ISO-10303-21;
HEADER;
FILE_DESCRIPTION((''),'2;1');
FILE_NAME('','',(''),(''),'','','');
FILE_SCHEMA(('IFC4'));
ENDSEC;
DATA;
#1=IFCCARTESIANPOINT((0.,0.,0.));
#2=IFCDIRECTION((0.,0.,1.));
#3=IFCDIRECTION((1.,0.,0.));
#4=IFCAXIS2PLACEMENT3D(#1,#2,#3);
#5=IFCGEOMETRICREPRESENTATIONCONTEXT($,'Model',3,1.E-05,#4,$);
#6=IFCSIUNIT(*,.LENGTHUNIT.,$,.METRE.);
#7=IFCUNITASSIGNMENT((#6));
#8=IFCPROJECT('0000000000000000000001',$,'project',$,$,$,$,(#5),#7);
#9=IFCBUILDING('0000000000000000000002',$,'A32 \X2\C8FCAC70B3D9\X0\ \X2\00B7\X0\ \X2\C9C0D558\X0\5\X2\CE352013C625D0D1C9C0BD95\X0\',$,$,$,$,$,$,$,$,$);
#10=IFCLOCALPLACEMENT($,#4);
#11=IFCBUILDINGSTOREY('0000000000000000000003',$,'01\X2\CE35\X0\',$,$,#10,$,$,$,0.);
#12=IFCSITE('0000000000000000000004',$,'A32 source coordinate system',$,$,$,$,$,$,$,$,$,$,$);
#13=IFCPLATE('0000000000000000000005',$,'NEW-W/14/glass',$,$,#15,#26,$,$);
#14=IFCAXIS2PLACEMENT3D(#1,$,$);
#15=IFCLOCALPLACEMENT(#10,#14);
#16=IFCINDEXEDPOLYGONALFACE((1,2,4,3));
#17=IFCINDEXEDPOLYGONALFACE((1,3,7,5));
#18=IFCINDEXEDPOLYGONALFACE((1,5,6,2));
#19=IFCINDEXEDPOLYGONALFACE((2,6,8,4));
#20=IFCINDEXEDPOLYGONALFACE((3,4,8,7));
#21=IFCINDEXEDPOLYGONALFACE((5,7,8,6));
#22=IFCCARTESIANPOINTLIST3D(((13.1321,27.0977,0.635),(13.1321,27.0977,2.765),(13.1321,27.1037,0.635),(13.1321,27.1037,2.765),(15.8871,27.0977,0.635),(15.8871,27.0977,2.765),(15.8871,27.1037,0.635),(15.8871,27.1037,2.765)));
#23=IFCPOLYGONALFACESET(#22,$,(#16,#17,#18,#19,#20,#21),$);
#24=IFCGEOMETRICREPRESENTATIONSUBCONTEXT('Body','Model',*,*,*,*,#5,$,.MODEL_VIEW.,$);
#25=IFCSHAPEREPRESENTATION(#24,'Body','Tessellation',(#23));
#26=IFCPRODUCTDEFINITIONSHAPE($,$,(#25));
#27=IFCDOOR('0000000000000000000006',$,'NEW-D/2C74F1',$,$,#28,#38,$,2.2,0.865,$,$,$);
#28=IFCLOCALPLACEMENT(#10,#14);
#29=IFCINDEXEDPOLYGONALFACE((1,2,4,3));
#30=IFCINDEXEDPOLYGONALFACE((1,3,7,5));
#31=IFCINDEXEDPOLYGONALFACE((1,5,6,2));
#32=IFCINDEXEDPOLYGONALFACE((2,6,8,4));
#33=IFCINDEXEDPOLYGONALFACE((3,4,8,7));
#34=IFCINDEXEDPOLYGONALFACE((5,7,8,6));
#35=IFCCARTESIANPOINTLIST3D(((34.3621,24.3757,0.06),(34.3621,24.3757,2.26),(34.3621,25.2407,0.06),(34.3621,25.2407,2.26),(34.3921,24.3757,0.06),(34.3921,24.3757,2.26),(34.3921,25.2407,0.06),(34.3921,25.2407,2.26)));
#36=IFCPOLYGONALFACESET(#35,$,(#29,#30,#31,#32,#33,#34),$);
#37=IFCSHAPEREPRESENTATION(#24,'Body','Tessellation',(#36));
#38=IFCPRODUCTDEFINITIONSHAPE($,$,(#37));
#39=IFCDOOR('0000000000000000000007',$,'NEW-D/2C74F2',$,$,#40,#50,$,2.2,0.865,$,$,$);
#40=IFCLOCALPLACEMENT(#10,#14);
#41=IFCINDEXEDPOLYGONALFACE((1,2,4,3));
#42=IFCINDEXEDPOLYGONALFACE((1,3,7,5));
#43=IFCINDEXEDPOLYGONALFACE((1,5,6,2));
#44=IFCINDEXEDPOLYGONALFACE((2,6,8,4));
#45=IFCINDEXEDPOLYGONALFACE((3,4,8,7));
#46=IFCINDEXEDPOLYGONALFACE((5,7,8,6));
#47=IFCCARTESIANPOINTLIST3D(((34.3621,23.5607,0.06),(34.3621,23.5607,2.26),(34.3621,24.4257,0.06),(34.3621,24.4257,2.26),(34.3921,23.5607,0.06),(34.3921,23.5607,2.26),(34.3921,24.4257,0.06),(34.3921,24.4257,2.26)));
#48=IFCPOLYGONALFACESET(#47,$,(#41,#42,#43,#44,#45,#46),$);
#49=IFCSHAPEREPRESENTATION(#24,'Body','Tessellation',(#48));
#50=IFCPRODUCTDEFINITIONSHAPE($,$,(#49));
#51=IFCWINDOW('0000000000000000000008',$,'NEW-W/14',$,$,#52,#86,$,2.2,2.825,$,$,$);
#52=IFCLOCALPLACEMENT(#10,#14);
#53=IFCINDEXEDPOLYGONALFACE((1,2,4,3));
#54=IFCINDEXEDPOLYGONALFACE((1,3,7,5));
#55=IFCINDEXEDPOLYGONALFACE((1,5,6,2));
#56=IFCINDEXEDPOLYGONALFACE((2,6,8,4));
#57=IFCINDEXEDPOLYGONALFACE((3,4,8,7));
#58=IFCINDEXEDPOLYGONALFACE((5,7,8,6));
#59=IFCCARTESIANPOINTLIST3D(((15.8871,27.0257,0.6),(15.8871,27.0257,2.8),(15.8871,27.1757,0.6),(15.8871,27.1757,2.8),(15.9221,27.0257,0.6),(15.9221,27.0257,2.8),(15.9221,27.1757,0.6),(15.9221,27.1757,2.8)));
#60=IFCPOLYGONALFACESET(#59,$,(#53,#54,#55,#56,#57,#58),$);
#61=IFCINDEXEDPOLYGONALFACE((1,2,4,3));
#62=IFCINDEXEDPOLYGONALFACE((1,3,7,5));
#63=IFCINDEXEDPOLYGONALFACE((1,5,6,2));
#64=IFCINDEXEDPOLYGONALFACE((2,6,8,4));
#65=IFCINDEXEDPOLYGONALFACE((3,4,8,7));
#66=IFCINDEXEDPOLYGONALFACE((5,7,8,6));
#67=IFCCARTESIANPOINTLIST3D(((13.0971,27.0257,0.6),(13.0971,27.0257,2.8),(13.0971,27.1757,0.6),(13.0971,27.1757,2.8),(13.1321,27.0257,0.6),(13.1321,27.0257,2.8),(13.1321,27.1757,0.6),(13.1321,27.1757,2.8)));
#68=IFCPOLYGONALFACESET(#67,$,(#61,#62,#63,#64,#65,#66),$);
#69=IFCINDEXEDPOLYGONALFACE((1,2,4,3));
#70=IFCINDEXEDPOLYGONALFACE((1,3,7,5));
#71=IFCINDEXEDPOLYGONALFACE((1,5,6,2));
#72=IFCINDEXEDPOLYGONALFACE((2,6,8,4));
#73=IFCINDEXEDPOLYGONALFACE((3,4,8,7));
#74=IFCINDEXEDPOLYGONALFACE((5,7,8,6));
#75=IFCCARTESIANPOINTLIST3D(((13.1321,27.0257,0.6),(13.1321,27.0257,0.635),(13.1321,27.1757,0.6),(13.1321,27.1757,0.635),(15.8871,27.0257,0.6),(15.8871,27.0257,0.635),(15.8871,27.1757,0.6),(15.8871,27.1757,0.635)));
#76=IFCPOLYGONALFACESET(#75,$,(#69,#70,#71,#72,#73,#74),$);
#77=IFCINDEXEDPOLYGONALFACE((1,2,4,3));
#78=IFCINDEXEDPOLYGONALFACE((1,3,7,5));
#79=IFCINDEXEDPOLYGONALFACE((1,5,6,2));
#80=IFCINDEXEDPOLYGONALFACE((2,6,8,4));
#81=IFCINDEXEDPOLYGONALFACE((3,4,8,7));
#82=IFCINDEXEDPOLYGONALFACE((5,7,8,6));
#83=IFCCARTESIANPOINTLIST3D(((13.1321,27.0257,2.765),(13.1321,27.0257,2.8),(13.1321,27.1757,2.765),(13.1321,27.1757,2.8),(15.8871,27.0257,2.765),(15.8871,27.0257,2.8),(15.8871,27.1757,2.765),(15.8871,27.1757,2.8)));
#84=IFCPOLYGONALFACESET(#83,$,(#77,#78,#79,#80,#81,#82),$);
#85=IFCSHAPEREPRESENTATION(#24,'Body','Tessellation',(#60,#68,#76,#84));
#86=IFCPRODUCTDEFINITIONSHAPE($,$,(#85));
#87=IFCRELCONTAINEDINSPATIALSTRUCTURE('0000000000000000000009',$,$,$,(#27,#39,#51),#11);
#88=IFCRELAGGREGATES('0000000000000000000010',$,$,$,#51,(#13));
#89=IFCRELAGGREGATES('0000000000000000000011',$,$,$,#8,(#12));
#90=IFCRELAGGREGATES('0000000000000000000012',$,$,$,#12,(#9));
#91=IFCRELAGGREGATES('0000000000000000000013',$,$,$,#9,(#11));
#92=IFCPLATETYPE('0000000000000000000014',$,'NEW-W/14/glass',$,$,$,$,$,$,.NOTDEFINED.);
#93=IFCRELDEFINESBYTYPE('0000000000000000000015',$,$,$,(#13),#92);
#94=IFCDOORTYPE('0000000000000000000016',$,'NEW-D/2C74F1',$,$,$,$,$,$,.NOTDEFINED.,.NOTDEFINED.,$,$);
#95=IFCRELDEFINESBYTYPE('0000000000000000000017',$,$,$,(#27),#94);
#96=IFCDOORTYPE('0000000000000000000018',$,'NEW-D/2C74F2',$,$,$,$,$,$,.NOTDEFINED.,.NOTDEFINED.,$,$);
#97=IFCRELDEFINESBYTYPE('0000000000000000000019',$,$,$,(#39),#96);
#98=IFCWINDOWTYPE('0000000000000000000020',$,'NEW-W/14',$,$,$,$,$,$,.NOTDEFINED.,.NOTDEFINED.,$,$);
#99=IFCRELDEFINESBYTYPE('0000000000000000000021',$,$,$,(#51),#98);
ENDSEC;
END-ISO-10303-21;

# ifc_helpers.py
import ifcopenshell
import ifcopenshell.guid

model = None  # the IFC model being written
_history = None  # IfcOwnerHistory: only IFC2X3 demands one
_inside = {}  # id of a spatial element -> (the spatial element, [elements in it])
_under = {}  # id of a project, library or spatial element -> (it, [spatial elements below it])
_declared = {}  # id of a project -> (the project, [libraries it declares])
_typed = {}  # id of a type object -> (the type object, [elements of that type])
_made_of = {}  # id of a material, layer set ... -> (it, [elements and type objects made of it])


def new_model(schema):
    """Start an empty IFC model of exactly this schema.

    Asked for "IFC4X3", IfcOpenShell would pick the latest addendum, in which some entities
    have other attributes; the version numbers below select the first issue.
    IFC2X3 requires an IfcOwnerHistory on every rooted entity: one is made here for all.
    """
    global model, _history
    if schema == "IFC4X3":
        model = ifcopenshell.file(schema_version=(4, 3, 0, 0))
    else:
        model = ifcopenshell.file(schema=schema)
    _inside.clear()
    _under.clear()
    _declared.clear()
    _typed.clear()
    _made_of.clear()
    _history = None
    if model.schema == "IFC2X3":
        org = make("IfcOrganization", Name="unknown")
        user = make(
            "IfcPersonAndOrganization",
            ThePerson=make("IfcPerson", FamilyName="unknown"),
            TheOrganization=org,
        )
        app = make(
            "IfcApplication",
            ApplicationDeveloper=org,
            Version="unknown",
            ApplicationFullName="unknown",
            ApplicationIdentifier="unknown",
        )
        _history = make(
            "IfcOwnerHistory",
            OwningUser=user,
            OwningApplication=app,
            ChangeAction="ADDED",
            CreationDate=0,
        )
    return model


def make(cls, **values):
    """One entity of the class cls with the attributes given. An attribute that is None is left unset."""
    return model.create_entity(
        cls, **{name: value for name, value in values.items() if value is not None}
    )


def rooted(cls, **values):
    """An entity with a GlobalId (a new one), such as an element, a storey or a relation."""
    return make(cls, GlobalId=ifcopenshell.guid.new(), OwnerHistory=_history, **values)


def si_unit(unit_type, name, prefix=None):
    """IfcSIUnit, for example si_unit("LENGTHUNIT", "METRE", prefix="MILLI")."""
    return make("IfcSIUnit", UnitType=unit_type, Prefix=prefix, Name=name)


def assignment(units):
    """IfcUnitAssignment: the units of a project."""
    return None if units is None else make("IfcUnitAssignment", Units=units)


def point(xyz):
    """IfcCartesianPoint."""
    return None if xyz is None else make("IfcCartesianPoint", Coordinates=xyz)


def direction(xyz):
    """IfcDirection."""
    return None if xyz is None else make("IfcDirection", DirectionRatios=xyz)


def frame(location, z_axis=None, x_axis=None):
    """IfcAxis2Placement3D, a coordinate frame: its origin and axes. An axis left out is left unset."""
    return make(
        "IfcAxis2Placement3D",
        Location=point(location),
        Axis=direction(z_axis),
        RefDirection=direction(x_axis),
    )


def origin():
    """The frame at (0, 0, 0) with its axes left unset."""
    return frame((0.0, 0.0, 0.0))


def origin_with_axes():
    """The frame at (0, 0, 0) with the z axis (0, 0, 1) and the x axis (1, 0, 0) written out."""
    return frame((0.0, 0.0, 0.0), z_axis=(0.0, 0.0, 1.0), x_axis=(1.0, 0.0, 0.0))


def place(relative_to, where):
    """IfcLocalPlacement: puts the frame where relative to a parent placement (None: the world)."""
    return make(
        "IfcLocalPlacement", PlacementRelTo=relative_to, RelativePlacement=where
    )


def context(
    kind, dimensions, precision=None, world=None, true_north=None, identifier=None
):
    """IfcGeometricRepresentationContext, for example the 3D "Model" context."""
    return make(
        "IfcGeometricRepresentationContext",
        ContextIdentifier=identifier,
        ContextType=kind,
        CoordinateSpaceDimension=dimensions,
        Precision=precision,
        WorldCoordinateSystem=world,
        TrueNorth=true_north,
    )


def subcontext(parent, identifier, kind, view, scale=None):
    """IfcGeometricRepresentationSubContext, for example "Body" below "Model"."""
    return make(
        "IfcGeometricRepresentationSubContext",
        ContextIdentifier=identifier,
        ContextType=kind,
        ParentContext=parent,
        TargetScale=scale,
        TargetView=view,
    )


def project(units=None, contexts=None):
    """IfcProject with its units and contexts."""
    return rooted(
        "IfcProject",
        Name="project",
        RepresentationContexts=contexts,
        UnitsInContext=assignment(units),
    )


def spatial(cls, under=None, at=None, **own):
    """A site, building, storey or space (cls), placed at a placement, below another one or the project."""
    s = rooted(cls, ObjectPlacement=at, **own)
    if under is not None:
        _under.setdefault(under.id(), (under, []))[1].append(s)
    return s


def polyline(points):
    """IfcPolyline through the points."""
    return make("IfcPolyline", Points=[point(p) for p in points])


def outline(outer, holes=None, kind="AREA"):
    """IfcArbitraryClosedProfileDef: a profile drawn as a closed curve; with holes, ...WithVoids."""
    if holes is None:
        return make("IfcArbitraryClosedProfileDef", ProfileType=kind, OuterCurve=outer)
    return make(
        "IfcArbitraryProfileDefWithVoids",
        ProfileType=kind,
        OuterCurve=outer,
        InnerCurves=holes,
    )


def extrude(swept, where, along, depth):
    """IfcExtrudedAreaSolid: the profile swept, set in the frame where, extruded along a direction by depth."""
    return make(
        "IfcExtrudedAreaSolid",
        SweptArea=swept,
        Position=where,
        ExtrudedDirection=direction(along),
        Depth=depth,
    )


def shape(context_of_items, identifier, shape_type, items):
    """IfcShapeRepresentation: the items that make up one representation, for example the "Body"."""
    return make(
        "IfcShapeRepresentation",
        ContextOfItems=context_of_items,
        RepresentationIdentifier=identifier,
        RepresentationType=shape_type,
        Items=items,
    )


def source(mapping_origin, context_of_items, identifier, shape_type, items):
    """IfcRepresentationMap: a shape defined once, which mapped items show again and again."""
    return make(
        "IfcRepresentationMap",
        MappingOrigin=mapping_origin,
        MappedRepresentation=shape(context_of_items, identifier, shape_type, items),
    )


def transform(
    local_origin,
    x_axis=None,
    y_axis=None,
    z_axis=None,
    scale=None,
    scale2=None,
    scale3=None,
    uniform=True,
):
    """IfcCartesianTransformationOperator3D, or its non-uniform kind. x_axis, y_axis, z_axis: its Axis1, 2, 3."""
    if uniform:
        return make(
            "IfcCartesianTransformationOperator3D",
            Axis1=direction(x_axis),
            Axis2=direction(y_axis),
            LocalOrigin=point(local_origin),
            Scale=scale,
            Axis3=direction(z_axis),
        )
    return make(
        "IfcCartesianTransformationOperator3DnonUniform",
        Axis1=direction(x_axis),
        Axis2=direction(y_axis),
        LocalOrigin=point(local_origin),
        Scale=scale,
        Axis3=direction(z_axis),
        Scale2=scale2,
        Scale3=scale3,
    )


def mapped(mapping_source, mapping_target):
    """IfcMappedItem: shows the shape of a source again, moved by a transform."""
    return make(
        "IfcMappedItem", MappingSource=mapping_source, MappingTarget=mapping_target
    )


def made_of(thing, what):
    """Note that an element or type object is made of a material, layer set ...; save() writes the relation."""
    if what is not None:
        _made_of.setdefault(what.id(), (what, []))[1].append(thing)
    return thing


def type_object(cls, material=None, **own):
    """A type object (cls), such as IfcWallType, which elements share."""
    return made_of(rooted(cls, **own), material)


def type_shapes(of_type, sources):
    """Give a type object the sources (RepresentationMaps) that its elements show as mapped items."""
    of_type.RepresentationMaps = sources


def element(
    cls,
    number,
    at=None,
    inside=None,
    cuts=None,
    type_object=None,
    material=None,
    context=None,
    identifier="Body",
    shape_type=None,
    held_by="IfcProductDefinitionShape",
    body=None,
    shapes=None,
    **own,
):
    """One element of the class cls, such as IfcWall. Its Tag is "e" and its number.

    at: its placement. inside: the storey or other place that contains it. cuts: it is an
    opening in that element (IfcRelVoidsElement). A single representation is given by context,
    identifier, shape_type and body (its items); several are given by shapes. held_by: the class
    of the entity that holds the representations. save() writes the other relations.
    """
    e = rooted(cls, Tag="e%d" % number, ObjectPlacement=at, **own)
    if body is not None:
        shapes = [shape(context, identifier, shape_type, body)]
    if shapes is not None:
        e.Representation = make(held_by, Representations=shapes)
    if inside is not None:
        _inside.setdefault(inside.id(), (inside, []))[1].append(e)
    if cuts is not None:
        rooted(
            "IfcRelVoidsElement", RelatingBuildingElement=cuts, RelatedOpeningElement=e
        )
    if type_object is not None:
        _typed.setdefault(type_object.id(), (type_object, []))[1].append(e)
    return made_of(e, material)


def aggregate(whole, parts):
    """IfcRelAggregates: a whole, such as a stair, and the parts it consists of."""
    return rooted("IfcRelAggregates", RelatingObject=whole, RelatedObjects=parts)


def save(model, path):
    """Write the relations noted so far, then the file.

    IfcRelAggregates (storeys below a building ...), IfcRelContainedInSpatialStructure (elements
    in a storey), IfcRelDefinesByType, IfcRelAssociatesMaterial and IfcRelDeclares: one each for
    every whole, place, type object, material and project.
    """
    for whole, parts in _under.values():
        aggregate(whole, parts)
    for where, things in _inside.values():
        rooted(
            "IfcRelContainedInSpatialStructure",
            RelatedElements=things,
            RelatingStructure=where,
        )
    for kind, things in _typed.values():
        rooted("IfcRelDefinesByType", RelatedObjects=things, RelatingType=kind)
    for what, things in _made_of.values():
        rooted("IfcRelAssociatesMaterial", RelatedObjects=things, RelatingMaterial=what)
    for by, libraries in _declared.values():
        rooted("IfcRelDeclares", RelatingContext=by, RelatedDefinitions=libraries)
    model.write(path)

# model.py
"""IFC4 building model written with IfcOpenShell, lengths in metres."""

from ifc_helpers import new_model, si_unit, frame, origin, origin_with_axes, place, context, subcontext, project, spatial, polyline, outline, extrude, source, transform, mapped, type_object, type_shapes, element, aggregate, save


model = new_model("IFC4")

# Units and contexts
model_context = context("Model", 3, precision=1e-05, world=origin_with_axes())
body_context = subcontext(model_context, "Body", "Model", "MODEL_VIEW")
ifc_project = project(units=[si_unit("LENGTHUNIT", "METRE")], contexts=[model_context])

# Plate
storey_placement = place(None, origin_with_axes())
plate_type_1 = type_object("IfcPlateType", Name="NEW-W/14/glass", PredefinedType="NOTDEFINED")
shared_shape_1 = source(origin(), body_context, "Body", "SweptSolid", [
    extrude(outline(polyline([(15.8871, 27.0977), (13.1321, 27.0977), (13.1321, 27.1037), (15.8871, 27.1037), (15.8871, 27.0977)])), frame((0.0, 0.0, 0.635)), (0.0, 0.0, 1.0), 2.13),
])
type_shapes(plate_type_1, [shared_shape_1])
window_1_placement = place(storey_placement, origin_with_axes())
plate_1_placement = place(window_1_placement, origin_with_axes())
plate_1 = element("IfcPlate", 1, at=plate_1_placement, type_object=plate_type_1, Name="NEW-W/14/glass", context=body_context, shape_type="MappedRepresentation", body=[
    mapped(shared_shape_1, transform((0.0, 0.0, 0.0), scale=1.0)),
])

# Site, building, storey
site = spatial("IfcSite", under=ifc_project, Name="A32 source coordinate system")
building = spatial("IfcBuilding", under=site, Name="A32 주거동 · 지하5층–옥탑지붕")
storey = spatial("IfcBuildingStorey", under=building, at=storey_placement, Name="01층", Elevation=0.0)

# Doors
door_type_1 = type_object("IfcDoorType", Name="NEW-D/2C74F1", OperationType="NOTDEFINED", PredefinedType="NOTDEFINED")
shared_shape_2 = source(origin(), body_context, "Body", "SweptSolid", [
    extrude(outline(polyline([(34.3621, 24.3757), (34.3621, 25.2407), (34.3921, 25.2407), (34.3921, 24.3757), (34.3621, 24.3757)])), frame((0.0, 0.0, 0.06)), (0.0, 0.0, 1.0), 2.2),
])
type_shapes(door_type_1, [shared_shape_2])
door_1_placement = place(storey_placement, origin_with_axes())
element("IfcDoor", 2, at=door_1_placement, inside=storey, type_object=door_type_1, Name="NEW-D/2C74F1", OverallHeight=2.2, OverallWidth=0.865, context=body_context, shape_type="MappedRepresentation", body=[
    mapped(shared_shape_2, transform((0.0, 0.0, 0.0), scale=1.0)),
])
door_type_2 = type_object("IfcDoorType", Name="NEW-D/2C74F2", OperationType="NOTDEFINED", PredefinedType="NOTDEFINED")
shared_shape_3 = source(origin(), body_context, "Body", "SweptSolid", [
    extrude(outline(polyline([(34.3921, 23.5607), (34.3621, 23.5607), (34.3621, 24.4257), (34.3921, 24.4257), (34.3921, 23.5607)])), frame((0.0, 0.0, 0.06)), (0.0, 0.0, 1.0), 2.2),
])
type_shapes(door_type_2, [shared_shape_3])
door_2_placement = place(storey_placement, origin_with_axes())
element("IfcDoor", 3, at=door_2_placement, inside=storey, type_object=door_type_2, Name="NEW-D/2C74F2", OverallHeight=2.2, OverallWidth=0.865, context=body_context, shape_type="MappedRepresentation", body=[
    mapped(shared_shape_3, transform((0.0, 0.0, 0.0), scale=1.0)),
])

# Window
window_type_1 = type_object("IfcWindowType", Name="NEW-W/14", PartitioningType="NOTDEFINED", PredefinedType="NOTDEFINED")
shared_shape_4 = source(origin(), body_context, "Body", "SweptSolid", [
    extrude(outline(polyline([(15.8871, 27.0257), (15.8871, 27.1757), (15.9221, 27.1757), (15.9221, 27.0257), (15.8871, 27.0257)])), frame((0.0, 0.0, 0.6)), (0.0, 0.0, 1.0), 2.2),
    extrude(outline(polyline([(13.0971, 27.0257), (13.0971, 27.1757), (13.1321, 27.1757), (13.1321, 27.0257), (13.0971, 27.0257)])), frame((0.0, 0.0, 0.6)), (0.0, 0.0, 1.0), 2.2),
    extrude(outline(polyline([(15.8871, 27.0257), (15.8871, 27.1757), (13.1321, 27.1757), (13.1321, 27.0257), (15.8871, 27.0257)])), frame((0.0, 0.0, 0.6)), (0.0, 0.0, 1.0), 0.035),
    extrude(outline(polyline([(15.8871, 27.0257), (15.8871, 27.1757), (13.1321, 27.1757), (13.1321, 27.0257), (15.8871, 27.0257)])), frame((0.0, 0.0, 2.765)), (0.0, 0.0, 1.0), 0.035),
])
type_shapes(window_type_1, [shared_shape_4])
window_1 = element("IfcWindow", 4, at=window_1_placement, inside=storey, type_object=window_type_1, Name="NEW-W/14", OverallHeight=2.2, OverallWidth=2.825, context=body_context, shape_type="MappedRepresentation", body=[
    mapped(shared_shape_4, transform((0.0, 0.0, 0.0), scale=1.0)),
])
aggregate(window_1, [plate_1])

save(model, "model.ifc")
